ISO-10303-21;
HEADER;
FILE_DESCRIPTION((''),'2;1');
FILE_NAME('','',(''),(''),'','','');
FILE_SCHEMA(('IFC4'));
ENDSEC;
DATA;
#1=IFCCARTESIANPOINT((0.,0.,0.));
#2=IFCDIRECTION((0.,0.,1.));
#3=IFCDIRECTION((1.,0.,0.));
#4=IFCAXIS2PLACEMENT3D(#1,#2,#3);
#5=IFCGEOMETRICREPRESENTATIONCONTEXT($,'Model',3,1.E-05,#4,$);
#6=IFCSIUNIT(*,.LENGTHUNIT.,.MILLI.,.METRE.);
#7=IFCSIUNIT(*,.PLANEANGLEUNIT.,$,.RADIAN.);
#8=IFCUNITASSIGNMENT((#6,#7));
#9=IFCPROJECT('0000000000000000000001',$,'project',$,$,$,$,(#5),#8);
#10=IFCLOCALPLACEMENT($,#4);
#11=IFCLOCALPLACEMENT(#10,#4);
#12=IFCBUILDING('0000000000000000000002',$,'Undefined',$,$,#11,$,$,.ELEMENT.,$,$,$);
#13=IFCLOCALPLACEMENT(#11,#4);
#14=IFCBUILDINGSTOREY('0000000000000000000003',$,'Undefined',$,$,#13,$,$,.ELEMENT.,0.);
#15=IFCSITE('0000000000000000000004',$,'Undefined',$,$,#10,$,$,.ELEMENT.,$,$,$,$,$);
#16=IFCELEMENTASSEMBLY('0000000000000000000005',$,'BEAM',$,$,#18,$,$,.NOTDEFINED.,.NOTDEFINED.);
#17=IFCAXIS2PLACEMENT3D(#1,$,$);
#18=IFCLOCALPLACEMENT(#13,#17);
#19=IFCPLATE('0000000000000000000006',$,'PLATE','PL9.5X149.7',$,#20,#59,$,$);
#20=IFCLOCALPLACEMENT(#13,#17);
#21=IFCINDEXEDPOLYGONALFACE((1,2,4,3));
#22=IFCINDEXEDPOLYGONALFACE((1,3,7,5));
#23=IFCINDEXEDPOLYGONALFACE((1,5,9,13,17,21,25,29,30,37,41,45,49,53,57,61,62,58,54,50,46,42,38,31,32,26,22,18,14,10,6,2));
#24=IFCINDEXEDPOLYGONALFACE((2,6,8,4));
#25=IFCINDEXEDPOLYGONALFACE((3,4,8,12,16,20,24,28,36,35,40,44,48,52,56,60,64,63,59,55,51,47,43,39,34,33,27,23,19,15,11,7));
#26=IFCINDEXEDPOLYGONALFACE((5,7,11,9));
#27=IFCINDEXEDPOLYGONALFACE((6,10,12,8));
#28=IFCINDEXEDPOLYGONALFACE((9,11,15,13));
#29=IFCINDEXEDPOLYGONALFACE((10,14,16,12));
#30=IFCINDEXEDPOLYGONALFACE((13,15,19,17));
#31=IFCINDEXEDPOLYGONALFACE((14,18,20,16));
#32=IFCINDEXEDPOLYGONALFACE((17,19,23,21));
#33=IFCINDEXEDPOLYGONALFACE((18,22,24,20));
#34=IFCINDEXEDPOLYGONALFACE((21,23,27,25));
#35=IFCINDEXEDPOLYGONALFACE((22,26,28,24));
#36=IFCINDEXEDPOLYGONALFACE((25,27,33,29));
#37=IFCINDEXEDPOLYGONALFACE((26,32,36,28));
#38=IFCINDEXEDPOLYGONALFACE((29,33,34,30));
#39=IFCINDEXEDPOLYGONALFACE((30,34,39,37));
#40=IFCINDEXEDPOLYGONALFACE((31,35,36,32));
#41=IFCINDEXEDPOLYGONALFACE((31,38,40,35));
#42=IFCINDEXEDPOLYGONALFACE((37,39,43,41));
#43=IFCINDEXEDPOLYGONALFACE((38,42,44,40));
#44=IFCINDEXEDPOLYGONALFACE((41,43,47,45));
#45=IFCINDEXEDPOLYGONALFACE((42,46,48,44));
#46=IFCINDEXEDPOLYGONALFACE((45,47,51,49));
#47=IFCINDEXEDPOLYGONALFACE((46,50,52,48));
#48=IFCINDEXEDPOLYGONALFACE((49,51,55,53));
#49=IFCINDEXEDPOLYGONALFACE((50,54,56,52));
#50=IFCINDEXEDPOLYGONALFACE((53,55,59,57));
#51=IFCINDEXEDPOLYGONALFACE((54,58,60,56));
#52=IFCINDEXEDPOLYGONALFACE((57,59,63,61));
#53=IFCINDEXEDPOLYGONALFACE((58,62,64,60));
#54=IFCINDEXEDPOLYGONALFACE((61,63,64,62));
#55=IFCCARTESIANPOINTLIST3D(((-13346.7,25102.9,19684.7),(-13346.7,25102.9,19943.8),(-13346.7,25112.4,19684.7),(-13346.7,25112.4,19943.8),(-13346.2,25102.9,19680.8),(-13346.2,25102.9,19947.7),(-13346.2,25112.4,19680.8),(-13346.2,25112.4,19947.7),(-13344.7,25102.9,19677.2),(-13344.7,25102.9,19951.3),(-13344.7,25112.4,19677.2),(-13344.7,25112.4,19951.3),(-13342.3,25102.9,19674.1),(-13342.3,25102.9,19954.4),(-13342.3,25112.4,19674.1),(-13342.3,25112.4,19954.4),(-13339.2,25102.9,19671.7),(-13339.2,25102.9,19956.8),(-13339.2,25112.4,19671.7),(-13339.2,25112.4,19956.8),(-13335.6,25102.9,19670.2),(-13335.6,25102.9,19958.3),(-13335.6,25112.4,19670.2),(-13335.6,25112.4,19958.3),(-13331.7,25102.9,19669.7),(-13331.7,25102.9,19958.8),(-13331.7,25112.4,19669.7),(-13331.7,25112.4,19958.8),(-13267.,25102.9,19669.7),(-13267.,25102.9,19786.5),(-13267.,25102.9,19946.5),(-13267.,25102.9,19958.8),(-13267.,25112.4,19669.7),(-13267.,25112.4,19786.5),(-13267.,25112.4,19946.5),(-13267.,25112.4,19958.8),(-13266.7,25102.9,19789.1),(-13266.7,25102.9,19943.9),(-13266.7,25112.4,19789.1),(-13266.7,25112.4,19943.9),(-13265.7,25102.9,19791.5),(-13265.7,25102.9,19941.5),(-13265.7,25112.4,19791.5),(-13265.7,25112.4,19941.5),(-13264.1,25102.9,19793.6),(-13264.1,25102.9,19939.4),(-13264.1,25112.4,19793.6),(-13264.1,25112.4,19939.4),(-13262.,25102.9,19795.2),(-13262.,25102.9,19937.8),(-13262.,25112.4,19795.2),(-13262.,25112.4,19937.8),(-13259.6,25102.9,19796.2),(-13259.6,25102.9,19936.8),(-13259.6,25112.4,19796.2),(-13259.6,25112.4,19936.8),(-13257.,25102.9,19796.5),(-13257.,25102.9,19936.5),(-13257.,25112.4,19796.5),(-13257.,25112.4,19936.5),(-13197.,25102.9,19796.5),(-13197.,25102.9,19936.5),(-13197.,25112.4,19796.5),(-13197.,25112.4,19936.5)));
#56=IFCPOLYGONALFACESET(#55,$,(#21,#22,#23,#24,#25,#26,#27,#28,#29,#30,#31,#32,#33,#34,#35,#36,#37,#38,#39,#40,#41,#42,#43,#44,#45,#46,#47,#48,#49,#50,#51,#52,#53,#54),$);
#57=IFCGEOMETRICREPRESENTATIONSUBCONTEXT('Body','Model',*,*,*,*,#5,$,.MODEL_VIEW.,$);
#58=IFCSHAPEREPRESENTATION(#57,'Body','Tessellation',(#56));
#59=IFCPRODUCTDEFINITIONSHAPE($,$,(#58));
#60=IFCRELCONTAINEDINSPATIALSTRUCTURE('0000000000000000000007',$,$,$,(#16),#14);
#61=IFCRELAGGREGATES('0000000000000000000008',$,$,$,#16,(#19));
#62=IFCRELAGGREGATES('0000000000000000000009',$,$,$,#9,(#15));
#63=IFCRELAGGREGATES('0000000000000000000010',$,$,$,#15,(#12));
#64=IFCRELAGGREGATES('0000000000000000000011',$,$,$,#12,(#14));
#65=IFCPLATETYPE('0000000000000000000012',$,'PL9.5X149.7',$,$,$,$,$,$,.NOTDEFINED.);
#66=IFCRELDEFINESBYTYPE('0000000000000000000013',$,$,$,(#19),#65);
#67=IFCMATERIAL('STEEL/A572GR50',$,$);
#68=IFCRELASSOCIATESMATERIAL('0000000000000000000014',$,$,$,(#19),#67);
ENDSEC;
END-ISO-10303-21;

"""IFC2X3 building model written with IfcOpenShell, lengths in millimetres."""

from ifc_helpers import new_model, si_unit, frame, frame_2d, origin_with_axes, place, context, subcontext, project, spatial, polyline, circle_curve, parameter, trimmed, segment, composite_curve, outline, extrude, material, type_object, element, aggregate, save


model = new_model("IFC2X3")

# Units and contexts
model_context = context("Model", 3, precision=1e-05, world=origin_with_axes())
body_context = subcontext(model_context, "Body", "Model", "MODEL_VIEW")
ifc_project = project(units=[si_unit("LENGTHUNIT", "METRE", prefix="MILLI"), si_unit("PLANEANGLEUNIT", "RADIAN")], contexts=[model_context])

# Site, building, storey
site_placement = place(None, origin_with_axes())
site = spatial("IfcSite", under=ifc_project, at=site_placement, Name="Undefined", CompositionType="ELEMENT")
building_placement = place(site_placement, origin_with_axes())
building = spatial("IfcBuilding", under=site, at=building_placement, Name="Undefined", CompositionType="ELEMENT")
storey_placement = place(building_placement, origin_with_axes())
storey = spatial("IfcBuildingStorey", under=building, at=storey_placement, Name="Undefined", CompositionType="ELEMENT", Elevation=0.0)

# Shared definitions
ifc_material_1 = material(Name="STEEL/A572GR50")

# Element assembly
assembly_1_placement = place(storey_placement, origin_with_axes())
assembly_1 = element("IfcElementAssembly", 1, at=assembly_1_placement, inside=storey, Name="BEAM", AssemblyPlace="NOTDEFINED", PredefinedType="NOTDEFINED")

# Plate
plate_type_1 = type_object("IfcPlateType", Name="PL9.5X149.7", PredefinedType="NOTDEFINED")
plate_1_placement = place(assembly_1_placement, frame((-13346.7, 25107.7, 19958.8), z_axis=(0.0, -1.0, 0.0), x_axis=(0.0, 0.0, -1.0)))
plate_1 = element("IfcPlate", 2, at=plate_1_placement, type_object=plate_type_1, material=ifc_material_1, Name="PLATE", Description="PL9.5X149.7", context=body_context, shape_type="SweptSolid", body=[
    extrude(outline(composite_curve([segment(trimmed(circle_curve(frame_2d((15.0, 15.0), x_axis=(-1.0, 0.0)), 15.0), [parameter(0.0)], [parameter(1.570796)], True, "PARAMETER"), True, "CONTINUOUS"), segment(polyline([(15.0, 0.0), (274.1, 0.0)]), True, "CONTINUOUS"), segment(trimmed(circle_curve(frame_2d((274.1, 15.0), x_axis=(0.0, -1.0)), 15.0), [parameter(0.0)], [parameter(1.570796)], True, "PARAMETER"), True, "CONTINUOUS"), segment(polyline([(289.1, 15.0), (289.1, 79.7), (172.3, 79.7)]), True, "CONTINUOUS"), segment(trimmed(circle_curve(frame_2d((172.3, 89.7), x_axis=(0.0, -1.0)), 10.0), [parameter(0.0)], [parameter(4.712389)], False, "PARAMETER"), True, "CONTINUOUS"), segment(polyline([(162.3, 89.7), (162.3, 149.7), (22.3, 149.7), (22.3, 89.7)]), True, "CONTINUOUS"), segment(trimmed(circle_curve(frame_2d((12.3, 89.7), x_axis=(1.0, 0.0)), 10.0), [parameter(0.0)], [parameter(4.712389)], False, "PARAMETER"), True, "CONTINUOUS"), segment(polyline([(12.3, 79.7), (0.0, 79.7), (0.0, 15.0)]), True, "CONTINUOUS")], self_intersect=True)), frame((0.0, 0.0, -4.8), z_axis=(0.0, 0.0, 1.0), x_axis=(1.0, 0.0, 0.0)), (0.0, 0.0, 1.0), 9.5),
])

aggregate(assembly_1, [plate_1])

save(model, "model.ifc")
